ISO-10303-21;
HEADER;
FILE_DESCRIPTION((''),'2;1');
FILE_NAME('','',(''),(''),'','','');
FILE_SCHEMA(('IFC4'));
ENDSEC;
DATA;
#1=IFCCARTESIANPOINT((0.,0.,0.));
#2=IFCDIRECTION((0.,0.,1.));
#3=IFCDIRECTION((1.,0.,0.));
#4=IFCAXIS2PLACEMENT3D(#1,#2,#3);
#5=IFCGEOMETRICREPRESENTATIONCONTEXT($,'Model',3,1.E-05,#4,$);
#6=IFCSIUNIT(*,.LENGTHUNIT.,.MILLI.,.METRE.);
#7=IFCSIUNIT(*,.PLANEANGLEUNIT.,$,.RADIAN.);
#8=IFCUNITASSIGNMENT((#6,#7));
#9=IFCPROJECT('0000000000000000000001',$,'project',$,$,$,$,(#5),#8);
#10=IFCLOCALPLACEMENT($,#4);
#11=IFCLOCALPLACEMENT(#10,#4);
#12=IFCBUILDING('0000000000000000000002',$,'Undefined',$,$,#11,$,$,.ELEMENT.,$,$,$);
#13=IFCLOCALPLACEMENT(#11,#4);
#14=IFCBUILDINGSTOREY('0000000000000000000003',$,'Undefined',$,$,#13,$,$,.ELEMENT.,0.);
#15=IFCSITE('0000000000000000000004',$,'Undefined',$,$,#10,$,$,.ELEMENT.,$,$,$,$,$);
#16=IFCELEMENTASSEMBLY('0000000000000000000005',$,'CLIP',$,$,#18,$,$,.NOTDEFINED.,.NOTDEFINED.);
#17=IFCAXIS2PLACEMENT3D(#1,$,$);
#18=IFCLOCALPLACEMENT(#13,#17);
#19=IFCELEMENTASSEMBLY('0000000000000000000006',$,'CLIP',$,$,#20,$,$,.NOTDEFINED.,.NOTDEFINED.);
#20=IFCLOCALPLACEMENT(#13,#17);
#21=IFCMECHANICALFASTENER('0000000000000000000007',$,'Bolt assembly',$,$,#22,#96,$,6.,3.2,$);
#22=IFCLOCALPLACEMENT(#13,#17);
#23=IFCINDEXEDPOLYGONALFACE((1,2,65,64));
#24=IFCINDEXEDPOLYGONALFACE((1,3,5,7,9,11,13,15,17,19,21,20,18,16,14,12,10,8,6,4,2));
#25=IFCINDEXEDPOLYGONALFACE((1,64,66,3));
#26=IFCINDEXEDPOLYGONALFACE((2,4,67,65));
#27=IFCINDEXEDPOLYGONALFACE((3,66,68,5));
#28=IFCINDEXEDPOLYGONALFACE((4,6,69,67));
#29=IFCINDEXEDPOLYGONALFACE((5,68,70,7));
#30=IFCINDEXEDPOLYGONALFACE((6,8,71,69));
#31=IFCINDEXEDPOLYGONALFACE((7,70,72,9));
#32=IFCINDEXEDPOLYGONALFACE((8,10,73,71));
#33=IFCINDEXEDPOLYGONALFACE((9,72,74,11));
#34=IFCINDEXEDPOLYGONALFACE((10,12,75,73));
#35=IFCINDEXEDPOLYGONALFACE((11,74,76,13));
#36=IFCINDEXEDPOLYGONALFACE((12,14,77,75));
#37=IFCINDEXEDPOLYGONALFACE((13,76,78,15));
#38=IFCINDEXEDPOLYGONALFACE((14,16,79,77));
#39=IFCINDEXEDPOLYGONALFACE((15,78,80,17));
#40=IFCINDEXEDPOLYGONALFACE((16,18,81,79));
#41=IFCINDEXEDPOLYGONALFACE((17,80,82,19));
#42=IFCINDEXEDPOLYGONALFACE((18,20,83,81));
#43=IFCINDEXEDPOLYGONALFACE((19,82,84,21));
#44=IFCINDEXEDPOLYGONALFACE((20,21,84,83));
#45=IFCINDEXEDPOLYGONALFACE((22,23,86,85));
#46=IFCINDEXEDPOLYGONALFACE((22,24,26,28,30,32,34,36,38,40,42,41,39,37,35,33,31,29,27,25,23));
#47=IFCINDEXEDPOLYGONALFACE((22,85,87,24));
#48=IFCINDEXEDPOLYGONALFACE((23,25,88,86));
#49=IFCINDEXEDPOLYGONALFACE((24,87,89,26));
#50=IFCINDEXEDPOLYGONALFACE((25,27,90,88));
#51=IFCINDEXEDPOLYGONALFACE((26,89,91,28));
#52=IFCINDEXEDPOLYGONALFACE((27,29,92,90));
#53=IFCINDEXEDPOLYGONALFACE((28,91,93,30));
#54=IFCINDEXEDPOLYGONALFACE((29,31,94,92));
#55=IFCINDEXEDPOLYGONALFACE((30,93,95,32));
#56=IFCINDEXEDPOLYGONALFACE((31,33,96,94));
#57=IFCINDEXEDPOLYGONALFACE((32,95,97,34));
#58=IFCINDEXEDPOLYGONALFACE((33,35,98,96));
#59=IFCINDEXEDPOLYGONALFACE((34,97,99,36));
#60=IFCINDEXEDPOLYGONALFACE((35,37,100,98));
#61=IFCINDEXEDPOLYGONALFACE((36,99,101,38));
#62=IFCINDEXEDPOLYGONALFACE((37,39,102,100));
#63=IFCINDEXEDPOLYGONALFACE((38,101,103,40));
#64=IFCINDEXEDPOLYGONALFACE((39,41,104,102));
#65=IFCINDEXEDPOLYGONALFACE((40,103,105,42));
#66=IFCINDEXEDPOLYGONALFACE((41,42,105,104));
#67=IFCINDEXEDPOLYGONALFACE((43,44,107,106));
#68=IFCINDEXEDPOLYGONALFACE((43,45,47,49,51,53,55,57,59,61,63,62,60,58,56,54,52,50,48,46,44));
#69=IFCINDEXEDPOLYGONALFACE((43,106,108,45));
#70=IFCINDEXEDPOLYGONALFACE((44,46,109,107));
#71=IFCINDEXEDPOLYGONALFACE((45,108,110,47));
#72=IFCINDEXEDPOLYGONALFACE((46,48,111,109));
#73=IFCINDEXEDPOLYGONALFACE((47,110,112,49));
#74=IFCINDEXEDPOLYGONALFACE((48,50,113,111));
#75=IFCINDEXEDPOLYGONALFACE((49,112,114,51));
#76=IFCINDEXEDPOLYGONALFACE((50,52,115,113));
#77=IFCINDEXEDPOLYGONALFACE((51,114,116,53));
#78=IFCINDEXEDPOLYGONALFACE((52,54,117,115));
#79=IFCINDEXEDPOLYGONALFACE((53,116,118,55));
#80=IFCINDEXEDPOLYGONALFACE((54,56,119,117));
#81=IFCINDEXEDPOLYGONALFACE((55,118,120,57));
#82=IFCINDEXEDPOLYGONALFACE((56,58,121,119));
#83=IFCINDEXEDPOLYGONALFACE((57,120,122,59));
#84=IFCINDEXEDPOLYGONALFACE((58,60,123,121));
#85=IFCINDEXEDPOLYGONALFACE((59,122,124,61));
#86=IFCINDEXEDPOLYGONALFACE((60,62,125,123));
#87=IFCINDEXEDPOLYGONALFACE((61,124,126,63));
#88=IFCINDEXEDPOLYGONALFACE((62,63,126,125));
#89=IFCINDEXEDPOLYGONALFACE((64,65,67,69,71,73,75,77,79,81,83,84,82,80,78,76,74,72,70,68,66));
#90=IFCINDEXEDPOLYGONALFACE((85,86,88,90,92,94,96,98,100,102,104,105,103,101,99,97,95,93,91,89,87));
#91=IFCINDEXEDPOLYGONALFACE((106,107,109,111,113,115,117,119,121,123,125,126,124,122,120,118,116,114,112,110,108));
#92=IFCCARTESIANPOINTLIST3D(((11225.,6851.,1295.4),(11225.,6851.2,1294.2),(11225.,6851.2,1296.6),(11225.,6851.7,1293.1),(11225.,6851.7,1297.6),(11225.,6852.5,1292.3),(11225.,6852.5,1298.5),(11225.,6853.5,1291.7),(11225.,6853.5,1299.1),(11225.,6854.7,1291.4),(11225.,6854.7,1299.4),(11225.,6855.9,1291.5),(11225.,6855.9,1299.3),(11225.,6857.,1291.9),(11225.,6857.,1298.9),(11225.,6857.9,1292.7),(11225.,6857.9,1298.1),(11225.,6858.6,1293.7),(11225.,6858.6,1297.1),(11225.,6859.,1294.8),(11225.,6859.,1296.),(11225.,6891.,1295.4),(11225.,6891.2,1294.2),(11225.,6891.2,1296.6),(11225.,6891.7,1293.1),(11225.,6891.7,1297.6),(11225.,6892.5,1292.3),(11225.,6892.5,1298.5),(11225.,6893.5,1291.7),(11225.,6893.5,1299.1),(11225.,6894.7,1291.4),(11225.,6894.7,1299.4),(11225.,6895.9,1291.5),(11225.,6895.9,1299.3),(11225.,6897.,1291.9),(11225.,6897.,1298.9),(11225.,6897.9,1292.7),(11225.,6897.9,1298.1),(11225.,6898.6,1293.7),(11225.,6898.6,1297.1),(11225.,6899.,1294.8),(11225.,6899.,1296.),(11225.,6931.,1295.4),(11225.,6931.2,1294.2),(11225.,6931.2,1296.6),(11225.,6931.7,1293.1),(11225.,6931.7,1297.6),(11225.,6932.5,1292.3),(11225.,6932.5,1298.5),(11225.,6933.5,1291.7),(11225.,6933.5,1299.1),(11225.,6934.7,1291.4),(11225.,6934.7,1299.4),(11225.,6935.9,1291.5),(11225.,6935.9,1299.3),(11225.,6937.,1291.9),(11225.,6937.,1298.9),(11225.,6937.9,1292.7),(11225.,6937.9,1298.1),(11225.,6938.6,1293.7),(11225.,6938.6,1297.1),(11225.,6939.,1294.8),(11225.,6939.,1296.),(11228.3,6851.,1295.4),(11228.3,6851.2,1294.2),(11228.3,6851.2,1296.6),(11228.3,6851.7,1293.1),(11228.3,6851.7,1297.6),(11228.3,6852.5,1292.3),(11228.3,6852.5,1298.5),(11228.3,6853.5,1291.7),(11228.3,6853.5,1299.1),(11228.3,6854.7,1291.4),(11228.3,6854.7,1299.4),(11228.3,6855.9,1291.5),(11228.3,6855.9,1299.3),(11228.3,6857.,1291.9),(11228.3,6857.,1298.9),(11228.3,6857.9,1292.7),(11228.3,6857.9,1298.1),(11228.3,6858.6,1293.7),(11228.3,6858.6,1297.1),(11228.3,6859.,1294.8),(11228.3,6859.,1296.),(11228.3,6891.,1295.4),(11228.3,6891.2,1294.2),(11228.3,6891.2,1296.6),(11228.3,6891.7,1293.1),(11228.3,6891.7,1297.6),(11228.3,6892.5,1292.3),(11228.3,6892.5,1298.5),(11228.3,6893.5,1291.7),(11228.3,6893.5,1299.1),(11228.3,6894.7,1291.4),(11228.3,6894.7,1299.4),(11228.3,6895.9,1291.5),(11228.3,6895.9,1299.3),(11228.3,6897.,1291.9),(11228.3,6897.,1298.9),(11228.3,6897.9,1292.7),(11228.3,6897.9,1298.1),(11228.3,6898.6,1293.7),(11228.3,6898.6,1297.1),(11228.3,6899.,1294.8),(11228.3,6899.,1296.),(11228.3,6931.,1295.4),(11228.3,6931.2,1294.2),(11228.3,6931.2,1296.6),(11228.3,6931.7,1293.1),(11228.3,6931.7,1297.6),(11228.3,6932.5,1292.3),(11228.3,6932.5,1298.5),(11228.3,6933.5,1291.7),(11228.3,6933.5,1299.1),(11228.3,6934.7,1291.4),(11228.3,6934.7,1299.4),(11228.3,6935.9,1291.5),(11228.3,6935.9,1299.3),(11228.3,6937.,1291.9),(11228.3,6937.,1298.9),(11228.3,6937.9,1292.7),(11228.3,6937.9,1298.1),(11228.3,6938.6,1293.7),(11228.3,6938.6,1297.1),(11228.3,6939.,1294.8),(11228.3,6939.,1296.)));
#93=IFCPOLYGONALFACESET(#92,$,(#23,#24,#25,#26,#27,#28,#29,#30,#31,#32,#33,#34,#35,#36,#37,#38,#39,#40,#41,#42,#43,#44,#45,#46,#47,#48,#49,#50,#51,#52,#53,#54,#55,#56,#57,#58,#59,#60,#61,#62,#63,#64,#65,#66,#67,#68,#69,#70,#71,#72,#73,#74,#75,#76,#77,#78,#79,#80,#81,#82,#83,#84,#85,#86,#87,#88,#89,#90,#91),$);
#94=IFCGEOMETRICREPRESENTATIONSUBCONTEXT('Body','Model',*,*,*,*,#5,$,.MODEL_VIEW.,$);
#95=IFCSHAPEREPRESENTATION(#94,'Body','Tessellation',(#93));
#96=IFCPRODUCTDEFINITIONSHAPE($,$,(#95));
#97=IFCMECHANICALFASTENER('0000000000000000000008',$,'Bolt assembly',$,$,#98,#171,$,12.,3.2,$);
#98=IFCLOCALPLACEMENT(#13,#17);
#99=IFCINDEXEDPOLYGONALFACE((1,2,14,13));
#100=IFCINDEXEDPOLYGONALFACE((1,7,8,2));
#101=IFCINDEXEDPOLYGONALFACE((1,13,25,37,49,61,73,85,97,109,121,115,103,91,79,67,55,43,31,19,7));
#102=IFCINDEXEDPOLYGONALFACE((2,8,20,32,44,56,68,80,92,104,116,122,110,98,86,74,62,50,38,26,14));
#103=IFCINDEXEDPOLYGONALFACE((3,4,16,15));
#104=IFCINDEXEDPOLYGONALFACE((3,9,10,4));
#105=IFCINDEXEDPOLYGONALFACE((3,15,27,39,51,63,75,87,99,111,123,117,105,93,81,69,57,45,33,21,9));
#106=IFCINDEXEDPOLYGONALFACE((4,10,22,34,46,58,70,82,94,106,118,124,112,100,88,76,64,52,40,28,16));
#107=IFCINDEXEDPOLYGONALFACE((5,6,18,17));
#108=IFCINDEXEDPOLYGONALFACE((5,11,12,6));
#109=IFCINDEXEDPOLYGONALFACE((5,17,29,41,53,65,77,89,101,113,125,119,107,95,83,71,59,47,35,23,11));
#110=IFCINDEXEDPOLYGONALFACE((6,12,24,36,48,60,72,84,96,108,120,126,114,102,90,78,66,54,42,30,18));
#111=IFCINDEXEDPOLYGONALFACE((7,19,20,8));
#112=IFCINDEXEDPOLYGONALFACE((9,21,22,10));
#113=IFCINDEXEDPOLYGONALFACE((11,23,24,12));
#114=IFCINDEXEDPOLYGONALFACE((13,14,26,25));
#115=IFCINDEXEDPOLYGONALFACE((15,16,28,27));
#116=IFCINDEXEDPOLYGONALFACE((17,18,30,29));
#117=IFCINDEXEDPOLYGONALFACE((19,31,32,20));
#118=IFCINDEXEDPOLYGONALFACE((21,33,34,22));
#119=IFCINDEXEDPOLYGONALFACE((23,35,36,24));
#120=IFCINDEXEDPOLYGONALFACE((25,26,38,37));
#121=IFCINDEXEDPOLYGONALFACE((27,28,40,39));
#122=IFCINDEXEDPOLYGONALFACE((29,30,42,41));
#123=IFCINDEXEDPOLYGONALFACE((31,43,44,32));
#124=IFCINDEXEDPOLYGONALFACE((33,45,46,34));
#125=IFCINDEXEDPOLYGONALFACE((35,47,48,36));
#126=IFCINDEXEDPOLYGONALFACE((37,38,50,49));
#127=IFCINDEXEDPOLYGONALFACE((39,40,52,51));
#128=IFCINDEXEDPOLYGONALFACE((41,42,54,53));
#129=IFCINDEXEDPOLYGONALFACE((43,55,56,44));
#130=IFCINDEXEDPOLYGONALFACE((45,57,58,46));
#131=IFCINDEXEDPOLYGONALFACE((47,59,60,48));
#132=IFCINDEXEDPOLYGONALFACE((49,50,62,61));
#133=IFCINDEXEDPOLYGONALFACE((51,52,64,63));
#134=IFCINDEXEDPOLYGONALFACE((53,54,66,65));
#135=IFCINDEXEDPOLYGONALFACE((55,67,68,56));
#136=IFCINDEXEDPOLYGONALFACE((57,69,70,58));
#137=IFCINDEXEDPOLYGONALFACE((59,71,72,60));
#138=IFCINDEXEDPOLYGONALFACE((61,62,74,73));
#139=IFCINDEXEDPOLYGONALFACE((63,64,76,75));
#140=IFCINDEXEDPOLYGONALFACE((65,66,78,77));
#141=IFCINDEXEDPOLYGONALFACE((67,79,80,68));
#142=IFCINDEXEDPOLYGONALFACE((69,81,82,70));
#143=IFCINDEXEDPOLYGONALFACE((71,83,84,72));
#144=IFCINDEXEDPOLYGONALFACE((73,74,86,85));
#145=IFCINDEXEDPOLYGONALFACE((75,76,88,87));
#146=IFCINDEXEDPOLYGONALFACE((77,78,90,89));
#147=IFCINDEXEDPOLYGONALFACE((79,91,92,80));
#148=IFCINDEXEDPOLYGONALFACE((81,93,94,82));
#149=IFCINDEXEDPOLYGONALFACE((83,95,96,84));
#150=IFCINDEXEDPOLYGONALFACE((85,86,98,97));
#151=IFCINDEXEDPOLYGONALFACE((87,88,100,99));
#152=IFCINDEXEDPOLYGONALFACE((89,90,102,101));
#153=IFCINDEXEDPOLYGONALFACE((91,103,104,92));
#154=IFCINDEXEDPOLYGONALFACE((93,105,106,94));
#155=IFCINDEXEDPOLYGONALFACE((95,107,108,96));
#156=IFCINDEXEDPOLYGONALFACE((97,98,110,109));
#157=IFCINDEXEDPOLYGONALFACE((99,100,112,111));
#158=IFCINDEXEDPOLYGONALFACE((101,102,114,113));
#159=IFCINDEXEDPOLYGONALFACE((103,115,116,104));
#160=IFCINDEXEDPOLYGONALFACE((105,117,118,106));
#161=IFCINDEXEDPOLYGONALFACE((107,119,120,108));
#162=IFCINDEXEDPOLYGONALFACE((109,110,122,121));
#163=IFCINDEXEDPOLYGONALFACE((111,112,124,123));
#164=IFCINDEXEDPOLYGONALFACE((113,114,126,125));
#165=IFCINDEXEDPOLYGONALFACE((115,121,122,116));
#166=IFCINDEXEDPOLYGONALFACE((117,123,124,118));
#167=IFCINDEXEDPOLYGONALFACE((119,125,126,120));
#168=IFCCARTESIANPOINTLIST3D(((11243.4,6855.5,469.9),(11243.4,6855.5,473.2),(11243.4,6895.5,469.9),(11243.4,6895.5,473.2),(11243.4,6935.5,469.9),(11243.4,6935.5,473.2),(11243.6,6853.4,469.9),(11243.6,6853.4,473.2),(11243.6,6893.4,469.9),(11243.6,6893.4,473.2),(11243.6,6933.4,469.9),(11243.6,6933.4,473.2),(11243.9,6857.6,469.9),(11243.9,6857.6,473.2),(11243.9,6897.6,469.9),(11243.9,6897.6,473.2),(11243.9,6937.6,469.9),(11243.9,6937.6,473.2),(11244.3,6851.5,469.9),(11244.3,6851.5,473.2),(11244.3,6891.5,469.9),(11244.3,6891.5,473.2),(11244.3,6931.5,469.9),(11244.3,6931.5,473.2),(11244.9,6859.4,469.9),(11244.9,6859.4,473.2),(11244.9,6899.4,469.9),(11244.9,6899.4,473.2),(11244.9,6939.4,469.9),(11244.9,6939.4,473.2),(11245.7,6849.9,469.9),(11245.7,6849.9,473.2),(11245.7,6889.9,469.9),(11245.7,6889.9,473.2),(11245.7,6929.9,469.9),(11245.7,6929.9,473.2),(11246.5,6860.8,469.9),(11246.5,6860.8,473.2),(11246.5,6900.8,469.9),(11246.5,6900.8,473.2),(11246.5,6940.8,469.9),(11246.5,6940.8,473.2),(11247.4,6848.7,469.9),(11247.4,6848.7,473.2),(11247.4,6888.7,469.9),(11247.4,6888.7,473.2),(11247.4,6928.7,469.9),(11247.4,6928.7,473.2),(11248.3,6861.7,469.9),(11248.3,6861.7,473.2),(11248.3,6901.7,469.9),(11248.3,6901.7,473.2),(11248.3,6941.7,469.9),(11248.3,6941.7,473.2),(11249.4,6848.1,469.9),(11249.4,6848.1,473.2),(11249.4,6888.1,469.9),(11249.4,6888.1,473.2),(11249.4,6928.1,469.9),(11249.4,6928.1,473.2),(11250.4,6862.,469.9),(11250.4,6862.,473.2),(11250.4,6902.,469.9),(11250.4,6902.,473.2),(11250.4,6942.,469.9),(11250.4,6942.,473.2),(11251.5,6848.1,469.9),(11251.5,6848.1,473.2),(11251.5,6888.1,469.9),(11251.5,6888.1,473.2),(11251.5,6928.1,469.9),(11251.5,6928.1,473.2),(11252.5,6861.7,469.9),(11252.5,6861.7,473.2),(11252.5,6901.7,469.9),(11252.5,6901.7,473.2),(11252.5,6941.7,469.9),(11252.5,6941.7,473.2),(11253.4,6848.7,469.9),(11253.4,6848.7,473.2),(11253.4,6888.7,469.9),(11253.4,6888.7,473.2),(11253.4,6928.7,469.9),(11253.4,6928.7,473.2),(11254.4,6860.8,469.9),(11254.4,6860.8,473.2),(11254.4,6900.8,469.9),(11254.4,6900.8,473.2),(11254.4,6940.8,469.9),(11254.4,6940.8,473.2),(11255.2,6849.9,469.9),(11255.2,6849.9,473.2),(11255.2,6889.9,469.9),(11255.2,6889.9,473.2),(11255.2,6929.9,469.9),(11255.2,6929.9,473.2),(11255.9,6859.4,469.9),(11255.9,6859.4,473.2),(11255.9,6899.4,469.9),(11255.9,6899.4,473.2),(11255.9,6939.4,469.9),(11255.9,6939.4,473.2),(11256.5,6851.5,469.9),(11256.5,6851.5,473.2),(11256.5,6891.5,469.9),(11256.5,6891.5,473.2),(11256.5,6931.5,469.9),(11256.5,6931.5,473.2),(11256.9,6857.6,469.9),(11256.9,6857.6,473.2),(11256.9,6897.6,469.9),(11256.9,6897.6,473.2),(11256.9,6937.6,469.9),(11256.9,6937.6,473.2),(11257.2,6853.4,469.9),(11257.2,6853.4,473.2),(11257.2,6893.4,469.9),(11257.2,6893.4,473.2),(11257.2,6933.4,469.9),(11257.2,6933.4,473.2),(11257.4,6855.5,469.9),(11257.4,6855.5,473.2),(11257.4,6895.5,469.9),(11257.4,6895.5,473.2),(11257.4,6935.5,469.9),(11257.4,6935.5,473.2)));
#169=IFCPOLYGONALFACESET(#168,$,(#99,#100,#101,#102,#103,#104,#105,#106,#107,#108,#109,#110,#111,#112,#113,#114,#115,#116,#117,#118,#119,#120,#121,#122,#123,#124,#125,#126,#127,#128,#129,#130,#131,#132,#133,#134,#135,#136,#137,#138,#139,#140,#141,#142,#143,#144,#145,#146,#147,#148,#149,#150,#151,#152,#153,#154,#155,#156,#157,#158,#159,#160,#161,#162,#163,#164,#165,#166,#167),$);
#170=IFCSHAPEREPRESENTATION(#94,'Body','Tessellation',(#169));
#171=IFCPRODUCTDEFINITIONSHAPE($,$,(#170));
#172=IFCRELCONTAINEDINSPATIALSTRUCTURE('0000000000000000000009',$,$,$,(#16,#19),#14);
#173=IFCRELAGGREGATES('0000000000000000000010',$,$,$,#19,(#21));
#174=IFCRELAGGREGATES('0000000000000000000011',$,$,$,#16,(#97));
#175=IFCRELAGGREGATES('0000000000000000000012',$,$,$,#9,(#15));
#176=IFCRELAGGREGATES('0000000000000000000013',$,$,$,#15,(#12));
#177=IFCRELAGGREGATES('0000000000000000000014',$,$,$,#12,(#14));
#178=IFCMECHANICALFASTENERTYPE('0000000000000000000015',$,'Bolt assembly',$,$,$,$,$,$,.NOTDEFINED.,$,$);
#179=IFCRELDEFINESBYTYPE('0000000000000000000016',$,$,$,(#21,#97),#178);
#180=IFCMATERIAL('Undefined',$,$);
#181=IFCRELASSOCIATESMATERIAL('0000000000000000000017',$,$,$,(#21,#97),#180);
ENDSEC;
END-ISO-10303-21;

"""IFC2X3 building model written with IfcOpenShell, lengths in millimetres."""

from ifc_helpers import new_model, si_unit, frame, origin_with_axes, origin_2d_with_axis, place, context, subcontext, project, spatial, circle, extrude, source, transform, mapped, material, type_object, element, aggregate, save


model = new_model("IFC2X3")

# Units and contexts
model_context = context("Model", 3, precision=1e-05, world=origin_with_axes())
body_context = subcontext(model_context, "Body", "Model", "MODEL_VIEW")
ifc_project = project(units=[si_unit("LENGTHUNIT", "METRE", prefix="MILLI"), si_unit("PLANEANGLEUNIT", "RADIAN")], contexts=[model_context])

# Site, building, storey
site_placement = place(None, origin_with_axes())
site = spatial("IfcSite", under=ifc_project, at=site_placement, Name="Undefined", CompositionType="ELEMENT")
building_placement = place(site_placement, origin_with_axes())
building = spatial("IfcBuilding", under=site, at=building_placement, Name="Undefined", CompositionType="ELEMENT")
storey_placement = place(building_placement, origin_with_axes())
storey = spatial("IfcBuildingStorey", under=building, at=storey_placement, Name="Undefined", CompositionType="ELEMENT", Elevation=0.0)

# Element assemblies
assembly_1_placement = place(storey_placement, origin_with_axes())
assembly_1 = element("IfcElementAssembly", 1, at=assembly_1_placement, inside=storey, Name="CLIP", AssemblyPlace="NOTDEFINED", PredefinedType="NOTDEFINED")
assembly_2_placement = place(storey_placement, origin_with_axes())
assembly_2 = element("IfcElementAssembly", 2, at=assembly_2_placement, inside=storey, Name="CLIP", AssemblyPlace="NOTDEFINED", PredefinedType="NOTDEFINED")

# Mechanical fasteners
ifc_material_1 = material(Name="Undefined")
mechanical_fastener_type = type_object("IfcMechanicalFastenerType", Name="Bolt assembly")
shared_shape_1 = source(origin_with_axes(), body_context, "Body", "SweptSolid", [
    extrude(circle(Radius=4.0, at=origin_2d_with_axis()), frame((0.0, 0.0, 0.0), z_axis=(0.0, 1.0, 0.0), x_axis=(1.0, 0.0, 0.0)), (0.0, 0.0, 1.0), 3.3),
])
mechanical_fastener_1_placement = place(assembly_2_placement, frame((11225.0, 6935.0, 1295.4), z_axis=(0.0, 0.0, 1.0), x_axis=(0.0, -1.0, 0.0)))
mechanical_fastener_1 = element("IfcMechanicalFastener", 3, at=mechanical_fastener_1_placement, type_object=mechanical_fastener_type, material=ifc_material_1, Name="Bolt assembly", NominalDiameter=6.0, NominalLength=3.2, context=body_context, shape_type="MappedRepresentation", body=[
    mapped(shared_shape_1, transform((0.0, 0.0, 0.0))),
    mapped(shared_shape_1, transform((40.0, 0.0, 0.0))),
    mapped(shared_shape_1, transform((80.0, 0.0, 0.0))),
])
aggregate(assembly_2, [mechanical_fastener_1])
shared_shape_2 = source(origin_with_axes(), body_context, "Body", "SweptSolid", [
    extrude(circle(Radius=7.0, at=origin_2d_with_axis()), frame((0.0, -3.2, 0.0), z_axis=(0.0, 1.0, 0.0), x_axis=(1.0, 0.0, 0.0)), (0.0, 0.0, 1.0), 3.3),
])
mechanical_fastener_2_placement = place(assembly_1_placement, frame((11250.4, 6855.0, 470.0), z_axis=(-1.0, 0.0, 0.0), x_axis=(0.0, 1.0, 0.0)))
mechanical_fastener_2 = element("IfcMechanicalFastener", 4, at=mechanical_fastener_2_placement, type_object=mechanical_fastener_type, material=ifc_material_1, Name="Bolt assembly", NominalDiameter=12.0, NominalLength=3.2, context=body_context, shape_type="MappedRepresentation", body=[
    mapped(shared_shape_2, transform((0.0, 0.0, 0.0))),
    mapped(shared_shape_2, transform((40.0, 0.0, 0.0))),
    mapped(shared_shape_2, transform((80.0, 0.0, 0.0))),
])
aggregate(assembly_1, [mechanical_fastener_2])

save(model, "model.ifc")
